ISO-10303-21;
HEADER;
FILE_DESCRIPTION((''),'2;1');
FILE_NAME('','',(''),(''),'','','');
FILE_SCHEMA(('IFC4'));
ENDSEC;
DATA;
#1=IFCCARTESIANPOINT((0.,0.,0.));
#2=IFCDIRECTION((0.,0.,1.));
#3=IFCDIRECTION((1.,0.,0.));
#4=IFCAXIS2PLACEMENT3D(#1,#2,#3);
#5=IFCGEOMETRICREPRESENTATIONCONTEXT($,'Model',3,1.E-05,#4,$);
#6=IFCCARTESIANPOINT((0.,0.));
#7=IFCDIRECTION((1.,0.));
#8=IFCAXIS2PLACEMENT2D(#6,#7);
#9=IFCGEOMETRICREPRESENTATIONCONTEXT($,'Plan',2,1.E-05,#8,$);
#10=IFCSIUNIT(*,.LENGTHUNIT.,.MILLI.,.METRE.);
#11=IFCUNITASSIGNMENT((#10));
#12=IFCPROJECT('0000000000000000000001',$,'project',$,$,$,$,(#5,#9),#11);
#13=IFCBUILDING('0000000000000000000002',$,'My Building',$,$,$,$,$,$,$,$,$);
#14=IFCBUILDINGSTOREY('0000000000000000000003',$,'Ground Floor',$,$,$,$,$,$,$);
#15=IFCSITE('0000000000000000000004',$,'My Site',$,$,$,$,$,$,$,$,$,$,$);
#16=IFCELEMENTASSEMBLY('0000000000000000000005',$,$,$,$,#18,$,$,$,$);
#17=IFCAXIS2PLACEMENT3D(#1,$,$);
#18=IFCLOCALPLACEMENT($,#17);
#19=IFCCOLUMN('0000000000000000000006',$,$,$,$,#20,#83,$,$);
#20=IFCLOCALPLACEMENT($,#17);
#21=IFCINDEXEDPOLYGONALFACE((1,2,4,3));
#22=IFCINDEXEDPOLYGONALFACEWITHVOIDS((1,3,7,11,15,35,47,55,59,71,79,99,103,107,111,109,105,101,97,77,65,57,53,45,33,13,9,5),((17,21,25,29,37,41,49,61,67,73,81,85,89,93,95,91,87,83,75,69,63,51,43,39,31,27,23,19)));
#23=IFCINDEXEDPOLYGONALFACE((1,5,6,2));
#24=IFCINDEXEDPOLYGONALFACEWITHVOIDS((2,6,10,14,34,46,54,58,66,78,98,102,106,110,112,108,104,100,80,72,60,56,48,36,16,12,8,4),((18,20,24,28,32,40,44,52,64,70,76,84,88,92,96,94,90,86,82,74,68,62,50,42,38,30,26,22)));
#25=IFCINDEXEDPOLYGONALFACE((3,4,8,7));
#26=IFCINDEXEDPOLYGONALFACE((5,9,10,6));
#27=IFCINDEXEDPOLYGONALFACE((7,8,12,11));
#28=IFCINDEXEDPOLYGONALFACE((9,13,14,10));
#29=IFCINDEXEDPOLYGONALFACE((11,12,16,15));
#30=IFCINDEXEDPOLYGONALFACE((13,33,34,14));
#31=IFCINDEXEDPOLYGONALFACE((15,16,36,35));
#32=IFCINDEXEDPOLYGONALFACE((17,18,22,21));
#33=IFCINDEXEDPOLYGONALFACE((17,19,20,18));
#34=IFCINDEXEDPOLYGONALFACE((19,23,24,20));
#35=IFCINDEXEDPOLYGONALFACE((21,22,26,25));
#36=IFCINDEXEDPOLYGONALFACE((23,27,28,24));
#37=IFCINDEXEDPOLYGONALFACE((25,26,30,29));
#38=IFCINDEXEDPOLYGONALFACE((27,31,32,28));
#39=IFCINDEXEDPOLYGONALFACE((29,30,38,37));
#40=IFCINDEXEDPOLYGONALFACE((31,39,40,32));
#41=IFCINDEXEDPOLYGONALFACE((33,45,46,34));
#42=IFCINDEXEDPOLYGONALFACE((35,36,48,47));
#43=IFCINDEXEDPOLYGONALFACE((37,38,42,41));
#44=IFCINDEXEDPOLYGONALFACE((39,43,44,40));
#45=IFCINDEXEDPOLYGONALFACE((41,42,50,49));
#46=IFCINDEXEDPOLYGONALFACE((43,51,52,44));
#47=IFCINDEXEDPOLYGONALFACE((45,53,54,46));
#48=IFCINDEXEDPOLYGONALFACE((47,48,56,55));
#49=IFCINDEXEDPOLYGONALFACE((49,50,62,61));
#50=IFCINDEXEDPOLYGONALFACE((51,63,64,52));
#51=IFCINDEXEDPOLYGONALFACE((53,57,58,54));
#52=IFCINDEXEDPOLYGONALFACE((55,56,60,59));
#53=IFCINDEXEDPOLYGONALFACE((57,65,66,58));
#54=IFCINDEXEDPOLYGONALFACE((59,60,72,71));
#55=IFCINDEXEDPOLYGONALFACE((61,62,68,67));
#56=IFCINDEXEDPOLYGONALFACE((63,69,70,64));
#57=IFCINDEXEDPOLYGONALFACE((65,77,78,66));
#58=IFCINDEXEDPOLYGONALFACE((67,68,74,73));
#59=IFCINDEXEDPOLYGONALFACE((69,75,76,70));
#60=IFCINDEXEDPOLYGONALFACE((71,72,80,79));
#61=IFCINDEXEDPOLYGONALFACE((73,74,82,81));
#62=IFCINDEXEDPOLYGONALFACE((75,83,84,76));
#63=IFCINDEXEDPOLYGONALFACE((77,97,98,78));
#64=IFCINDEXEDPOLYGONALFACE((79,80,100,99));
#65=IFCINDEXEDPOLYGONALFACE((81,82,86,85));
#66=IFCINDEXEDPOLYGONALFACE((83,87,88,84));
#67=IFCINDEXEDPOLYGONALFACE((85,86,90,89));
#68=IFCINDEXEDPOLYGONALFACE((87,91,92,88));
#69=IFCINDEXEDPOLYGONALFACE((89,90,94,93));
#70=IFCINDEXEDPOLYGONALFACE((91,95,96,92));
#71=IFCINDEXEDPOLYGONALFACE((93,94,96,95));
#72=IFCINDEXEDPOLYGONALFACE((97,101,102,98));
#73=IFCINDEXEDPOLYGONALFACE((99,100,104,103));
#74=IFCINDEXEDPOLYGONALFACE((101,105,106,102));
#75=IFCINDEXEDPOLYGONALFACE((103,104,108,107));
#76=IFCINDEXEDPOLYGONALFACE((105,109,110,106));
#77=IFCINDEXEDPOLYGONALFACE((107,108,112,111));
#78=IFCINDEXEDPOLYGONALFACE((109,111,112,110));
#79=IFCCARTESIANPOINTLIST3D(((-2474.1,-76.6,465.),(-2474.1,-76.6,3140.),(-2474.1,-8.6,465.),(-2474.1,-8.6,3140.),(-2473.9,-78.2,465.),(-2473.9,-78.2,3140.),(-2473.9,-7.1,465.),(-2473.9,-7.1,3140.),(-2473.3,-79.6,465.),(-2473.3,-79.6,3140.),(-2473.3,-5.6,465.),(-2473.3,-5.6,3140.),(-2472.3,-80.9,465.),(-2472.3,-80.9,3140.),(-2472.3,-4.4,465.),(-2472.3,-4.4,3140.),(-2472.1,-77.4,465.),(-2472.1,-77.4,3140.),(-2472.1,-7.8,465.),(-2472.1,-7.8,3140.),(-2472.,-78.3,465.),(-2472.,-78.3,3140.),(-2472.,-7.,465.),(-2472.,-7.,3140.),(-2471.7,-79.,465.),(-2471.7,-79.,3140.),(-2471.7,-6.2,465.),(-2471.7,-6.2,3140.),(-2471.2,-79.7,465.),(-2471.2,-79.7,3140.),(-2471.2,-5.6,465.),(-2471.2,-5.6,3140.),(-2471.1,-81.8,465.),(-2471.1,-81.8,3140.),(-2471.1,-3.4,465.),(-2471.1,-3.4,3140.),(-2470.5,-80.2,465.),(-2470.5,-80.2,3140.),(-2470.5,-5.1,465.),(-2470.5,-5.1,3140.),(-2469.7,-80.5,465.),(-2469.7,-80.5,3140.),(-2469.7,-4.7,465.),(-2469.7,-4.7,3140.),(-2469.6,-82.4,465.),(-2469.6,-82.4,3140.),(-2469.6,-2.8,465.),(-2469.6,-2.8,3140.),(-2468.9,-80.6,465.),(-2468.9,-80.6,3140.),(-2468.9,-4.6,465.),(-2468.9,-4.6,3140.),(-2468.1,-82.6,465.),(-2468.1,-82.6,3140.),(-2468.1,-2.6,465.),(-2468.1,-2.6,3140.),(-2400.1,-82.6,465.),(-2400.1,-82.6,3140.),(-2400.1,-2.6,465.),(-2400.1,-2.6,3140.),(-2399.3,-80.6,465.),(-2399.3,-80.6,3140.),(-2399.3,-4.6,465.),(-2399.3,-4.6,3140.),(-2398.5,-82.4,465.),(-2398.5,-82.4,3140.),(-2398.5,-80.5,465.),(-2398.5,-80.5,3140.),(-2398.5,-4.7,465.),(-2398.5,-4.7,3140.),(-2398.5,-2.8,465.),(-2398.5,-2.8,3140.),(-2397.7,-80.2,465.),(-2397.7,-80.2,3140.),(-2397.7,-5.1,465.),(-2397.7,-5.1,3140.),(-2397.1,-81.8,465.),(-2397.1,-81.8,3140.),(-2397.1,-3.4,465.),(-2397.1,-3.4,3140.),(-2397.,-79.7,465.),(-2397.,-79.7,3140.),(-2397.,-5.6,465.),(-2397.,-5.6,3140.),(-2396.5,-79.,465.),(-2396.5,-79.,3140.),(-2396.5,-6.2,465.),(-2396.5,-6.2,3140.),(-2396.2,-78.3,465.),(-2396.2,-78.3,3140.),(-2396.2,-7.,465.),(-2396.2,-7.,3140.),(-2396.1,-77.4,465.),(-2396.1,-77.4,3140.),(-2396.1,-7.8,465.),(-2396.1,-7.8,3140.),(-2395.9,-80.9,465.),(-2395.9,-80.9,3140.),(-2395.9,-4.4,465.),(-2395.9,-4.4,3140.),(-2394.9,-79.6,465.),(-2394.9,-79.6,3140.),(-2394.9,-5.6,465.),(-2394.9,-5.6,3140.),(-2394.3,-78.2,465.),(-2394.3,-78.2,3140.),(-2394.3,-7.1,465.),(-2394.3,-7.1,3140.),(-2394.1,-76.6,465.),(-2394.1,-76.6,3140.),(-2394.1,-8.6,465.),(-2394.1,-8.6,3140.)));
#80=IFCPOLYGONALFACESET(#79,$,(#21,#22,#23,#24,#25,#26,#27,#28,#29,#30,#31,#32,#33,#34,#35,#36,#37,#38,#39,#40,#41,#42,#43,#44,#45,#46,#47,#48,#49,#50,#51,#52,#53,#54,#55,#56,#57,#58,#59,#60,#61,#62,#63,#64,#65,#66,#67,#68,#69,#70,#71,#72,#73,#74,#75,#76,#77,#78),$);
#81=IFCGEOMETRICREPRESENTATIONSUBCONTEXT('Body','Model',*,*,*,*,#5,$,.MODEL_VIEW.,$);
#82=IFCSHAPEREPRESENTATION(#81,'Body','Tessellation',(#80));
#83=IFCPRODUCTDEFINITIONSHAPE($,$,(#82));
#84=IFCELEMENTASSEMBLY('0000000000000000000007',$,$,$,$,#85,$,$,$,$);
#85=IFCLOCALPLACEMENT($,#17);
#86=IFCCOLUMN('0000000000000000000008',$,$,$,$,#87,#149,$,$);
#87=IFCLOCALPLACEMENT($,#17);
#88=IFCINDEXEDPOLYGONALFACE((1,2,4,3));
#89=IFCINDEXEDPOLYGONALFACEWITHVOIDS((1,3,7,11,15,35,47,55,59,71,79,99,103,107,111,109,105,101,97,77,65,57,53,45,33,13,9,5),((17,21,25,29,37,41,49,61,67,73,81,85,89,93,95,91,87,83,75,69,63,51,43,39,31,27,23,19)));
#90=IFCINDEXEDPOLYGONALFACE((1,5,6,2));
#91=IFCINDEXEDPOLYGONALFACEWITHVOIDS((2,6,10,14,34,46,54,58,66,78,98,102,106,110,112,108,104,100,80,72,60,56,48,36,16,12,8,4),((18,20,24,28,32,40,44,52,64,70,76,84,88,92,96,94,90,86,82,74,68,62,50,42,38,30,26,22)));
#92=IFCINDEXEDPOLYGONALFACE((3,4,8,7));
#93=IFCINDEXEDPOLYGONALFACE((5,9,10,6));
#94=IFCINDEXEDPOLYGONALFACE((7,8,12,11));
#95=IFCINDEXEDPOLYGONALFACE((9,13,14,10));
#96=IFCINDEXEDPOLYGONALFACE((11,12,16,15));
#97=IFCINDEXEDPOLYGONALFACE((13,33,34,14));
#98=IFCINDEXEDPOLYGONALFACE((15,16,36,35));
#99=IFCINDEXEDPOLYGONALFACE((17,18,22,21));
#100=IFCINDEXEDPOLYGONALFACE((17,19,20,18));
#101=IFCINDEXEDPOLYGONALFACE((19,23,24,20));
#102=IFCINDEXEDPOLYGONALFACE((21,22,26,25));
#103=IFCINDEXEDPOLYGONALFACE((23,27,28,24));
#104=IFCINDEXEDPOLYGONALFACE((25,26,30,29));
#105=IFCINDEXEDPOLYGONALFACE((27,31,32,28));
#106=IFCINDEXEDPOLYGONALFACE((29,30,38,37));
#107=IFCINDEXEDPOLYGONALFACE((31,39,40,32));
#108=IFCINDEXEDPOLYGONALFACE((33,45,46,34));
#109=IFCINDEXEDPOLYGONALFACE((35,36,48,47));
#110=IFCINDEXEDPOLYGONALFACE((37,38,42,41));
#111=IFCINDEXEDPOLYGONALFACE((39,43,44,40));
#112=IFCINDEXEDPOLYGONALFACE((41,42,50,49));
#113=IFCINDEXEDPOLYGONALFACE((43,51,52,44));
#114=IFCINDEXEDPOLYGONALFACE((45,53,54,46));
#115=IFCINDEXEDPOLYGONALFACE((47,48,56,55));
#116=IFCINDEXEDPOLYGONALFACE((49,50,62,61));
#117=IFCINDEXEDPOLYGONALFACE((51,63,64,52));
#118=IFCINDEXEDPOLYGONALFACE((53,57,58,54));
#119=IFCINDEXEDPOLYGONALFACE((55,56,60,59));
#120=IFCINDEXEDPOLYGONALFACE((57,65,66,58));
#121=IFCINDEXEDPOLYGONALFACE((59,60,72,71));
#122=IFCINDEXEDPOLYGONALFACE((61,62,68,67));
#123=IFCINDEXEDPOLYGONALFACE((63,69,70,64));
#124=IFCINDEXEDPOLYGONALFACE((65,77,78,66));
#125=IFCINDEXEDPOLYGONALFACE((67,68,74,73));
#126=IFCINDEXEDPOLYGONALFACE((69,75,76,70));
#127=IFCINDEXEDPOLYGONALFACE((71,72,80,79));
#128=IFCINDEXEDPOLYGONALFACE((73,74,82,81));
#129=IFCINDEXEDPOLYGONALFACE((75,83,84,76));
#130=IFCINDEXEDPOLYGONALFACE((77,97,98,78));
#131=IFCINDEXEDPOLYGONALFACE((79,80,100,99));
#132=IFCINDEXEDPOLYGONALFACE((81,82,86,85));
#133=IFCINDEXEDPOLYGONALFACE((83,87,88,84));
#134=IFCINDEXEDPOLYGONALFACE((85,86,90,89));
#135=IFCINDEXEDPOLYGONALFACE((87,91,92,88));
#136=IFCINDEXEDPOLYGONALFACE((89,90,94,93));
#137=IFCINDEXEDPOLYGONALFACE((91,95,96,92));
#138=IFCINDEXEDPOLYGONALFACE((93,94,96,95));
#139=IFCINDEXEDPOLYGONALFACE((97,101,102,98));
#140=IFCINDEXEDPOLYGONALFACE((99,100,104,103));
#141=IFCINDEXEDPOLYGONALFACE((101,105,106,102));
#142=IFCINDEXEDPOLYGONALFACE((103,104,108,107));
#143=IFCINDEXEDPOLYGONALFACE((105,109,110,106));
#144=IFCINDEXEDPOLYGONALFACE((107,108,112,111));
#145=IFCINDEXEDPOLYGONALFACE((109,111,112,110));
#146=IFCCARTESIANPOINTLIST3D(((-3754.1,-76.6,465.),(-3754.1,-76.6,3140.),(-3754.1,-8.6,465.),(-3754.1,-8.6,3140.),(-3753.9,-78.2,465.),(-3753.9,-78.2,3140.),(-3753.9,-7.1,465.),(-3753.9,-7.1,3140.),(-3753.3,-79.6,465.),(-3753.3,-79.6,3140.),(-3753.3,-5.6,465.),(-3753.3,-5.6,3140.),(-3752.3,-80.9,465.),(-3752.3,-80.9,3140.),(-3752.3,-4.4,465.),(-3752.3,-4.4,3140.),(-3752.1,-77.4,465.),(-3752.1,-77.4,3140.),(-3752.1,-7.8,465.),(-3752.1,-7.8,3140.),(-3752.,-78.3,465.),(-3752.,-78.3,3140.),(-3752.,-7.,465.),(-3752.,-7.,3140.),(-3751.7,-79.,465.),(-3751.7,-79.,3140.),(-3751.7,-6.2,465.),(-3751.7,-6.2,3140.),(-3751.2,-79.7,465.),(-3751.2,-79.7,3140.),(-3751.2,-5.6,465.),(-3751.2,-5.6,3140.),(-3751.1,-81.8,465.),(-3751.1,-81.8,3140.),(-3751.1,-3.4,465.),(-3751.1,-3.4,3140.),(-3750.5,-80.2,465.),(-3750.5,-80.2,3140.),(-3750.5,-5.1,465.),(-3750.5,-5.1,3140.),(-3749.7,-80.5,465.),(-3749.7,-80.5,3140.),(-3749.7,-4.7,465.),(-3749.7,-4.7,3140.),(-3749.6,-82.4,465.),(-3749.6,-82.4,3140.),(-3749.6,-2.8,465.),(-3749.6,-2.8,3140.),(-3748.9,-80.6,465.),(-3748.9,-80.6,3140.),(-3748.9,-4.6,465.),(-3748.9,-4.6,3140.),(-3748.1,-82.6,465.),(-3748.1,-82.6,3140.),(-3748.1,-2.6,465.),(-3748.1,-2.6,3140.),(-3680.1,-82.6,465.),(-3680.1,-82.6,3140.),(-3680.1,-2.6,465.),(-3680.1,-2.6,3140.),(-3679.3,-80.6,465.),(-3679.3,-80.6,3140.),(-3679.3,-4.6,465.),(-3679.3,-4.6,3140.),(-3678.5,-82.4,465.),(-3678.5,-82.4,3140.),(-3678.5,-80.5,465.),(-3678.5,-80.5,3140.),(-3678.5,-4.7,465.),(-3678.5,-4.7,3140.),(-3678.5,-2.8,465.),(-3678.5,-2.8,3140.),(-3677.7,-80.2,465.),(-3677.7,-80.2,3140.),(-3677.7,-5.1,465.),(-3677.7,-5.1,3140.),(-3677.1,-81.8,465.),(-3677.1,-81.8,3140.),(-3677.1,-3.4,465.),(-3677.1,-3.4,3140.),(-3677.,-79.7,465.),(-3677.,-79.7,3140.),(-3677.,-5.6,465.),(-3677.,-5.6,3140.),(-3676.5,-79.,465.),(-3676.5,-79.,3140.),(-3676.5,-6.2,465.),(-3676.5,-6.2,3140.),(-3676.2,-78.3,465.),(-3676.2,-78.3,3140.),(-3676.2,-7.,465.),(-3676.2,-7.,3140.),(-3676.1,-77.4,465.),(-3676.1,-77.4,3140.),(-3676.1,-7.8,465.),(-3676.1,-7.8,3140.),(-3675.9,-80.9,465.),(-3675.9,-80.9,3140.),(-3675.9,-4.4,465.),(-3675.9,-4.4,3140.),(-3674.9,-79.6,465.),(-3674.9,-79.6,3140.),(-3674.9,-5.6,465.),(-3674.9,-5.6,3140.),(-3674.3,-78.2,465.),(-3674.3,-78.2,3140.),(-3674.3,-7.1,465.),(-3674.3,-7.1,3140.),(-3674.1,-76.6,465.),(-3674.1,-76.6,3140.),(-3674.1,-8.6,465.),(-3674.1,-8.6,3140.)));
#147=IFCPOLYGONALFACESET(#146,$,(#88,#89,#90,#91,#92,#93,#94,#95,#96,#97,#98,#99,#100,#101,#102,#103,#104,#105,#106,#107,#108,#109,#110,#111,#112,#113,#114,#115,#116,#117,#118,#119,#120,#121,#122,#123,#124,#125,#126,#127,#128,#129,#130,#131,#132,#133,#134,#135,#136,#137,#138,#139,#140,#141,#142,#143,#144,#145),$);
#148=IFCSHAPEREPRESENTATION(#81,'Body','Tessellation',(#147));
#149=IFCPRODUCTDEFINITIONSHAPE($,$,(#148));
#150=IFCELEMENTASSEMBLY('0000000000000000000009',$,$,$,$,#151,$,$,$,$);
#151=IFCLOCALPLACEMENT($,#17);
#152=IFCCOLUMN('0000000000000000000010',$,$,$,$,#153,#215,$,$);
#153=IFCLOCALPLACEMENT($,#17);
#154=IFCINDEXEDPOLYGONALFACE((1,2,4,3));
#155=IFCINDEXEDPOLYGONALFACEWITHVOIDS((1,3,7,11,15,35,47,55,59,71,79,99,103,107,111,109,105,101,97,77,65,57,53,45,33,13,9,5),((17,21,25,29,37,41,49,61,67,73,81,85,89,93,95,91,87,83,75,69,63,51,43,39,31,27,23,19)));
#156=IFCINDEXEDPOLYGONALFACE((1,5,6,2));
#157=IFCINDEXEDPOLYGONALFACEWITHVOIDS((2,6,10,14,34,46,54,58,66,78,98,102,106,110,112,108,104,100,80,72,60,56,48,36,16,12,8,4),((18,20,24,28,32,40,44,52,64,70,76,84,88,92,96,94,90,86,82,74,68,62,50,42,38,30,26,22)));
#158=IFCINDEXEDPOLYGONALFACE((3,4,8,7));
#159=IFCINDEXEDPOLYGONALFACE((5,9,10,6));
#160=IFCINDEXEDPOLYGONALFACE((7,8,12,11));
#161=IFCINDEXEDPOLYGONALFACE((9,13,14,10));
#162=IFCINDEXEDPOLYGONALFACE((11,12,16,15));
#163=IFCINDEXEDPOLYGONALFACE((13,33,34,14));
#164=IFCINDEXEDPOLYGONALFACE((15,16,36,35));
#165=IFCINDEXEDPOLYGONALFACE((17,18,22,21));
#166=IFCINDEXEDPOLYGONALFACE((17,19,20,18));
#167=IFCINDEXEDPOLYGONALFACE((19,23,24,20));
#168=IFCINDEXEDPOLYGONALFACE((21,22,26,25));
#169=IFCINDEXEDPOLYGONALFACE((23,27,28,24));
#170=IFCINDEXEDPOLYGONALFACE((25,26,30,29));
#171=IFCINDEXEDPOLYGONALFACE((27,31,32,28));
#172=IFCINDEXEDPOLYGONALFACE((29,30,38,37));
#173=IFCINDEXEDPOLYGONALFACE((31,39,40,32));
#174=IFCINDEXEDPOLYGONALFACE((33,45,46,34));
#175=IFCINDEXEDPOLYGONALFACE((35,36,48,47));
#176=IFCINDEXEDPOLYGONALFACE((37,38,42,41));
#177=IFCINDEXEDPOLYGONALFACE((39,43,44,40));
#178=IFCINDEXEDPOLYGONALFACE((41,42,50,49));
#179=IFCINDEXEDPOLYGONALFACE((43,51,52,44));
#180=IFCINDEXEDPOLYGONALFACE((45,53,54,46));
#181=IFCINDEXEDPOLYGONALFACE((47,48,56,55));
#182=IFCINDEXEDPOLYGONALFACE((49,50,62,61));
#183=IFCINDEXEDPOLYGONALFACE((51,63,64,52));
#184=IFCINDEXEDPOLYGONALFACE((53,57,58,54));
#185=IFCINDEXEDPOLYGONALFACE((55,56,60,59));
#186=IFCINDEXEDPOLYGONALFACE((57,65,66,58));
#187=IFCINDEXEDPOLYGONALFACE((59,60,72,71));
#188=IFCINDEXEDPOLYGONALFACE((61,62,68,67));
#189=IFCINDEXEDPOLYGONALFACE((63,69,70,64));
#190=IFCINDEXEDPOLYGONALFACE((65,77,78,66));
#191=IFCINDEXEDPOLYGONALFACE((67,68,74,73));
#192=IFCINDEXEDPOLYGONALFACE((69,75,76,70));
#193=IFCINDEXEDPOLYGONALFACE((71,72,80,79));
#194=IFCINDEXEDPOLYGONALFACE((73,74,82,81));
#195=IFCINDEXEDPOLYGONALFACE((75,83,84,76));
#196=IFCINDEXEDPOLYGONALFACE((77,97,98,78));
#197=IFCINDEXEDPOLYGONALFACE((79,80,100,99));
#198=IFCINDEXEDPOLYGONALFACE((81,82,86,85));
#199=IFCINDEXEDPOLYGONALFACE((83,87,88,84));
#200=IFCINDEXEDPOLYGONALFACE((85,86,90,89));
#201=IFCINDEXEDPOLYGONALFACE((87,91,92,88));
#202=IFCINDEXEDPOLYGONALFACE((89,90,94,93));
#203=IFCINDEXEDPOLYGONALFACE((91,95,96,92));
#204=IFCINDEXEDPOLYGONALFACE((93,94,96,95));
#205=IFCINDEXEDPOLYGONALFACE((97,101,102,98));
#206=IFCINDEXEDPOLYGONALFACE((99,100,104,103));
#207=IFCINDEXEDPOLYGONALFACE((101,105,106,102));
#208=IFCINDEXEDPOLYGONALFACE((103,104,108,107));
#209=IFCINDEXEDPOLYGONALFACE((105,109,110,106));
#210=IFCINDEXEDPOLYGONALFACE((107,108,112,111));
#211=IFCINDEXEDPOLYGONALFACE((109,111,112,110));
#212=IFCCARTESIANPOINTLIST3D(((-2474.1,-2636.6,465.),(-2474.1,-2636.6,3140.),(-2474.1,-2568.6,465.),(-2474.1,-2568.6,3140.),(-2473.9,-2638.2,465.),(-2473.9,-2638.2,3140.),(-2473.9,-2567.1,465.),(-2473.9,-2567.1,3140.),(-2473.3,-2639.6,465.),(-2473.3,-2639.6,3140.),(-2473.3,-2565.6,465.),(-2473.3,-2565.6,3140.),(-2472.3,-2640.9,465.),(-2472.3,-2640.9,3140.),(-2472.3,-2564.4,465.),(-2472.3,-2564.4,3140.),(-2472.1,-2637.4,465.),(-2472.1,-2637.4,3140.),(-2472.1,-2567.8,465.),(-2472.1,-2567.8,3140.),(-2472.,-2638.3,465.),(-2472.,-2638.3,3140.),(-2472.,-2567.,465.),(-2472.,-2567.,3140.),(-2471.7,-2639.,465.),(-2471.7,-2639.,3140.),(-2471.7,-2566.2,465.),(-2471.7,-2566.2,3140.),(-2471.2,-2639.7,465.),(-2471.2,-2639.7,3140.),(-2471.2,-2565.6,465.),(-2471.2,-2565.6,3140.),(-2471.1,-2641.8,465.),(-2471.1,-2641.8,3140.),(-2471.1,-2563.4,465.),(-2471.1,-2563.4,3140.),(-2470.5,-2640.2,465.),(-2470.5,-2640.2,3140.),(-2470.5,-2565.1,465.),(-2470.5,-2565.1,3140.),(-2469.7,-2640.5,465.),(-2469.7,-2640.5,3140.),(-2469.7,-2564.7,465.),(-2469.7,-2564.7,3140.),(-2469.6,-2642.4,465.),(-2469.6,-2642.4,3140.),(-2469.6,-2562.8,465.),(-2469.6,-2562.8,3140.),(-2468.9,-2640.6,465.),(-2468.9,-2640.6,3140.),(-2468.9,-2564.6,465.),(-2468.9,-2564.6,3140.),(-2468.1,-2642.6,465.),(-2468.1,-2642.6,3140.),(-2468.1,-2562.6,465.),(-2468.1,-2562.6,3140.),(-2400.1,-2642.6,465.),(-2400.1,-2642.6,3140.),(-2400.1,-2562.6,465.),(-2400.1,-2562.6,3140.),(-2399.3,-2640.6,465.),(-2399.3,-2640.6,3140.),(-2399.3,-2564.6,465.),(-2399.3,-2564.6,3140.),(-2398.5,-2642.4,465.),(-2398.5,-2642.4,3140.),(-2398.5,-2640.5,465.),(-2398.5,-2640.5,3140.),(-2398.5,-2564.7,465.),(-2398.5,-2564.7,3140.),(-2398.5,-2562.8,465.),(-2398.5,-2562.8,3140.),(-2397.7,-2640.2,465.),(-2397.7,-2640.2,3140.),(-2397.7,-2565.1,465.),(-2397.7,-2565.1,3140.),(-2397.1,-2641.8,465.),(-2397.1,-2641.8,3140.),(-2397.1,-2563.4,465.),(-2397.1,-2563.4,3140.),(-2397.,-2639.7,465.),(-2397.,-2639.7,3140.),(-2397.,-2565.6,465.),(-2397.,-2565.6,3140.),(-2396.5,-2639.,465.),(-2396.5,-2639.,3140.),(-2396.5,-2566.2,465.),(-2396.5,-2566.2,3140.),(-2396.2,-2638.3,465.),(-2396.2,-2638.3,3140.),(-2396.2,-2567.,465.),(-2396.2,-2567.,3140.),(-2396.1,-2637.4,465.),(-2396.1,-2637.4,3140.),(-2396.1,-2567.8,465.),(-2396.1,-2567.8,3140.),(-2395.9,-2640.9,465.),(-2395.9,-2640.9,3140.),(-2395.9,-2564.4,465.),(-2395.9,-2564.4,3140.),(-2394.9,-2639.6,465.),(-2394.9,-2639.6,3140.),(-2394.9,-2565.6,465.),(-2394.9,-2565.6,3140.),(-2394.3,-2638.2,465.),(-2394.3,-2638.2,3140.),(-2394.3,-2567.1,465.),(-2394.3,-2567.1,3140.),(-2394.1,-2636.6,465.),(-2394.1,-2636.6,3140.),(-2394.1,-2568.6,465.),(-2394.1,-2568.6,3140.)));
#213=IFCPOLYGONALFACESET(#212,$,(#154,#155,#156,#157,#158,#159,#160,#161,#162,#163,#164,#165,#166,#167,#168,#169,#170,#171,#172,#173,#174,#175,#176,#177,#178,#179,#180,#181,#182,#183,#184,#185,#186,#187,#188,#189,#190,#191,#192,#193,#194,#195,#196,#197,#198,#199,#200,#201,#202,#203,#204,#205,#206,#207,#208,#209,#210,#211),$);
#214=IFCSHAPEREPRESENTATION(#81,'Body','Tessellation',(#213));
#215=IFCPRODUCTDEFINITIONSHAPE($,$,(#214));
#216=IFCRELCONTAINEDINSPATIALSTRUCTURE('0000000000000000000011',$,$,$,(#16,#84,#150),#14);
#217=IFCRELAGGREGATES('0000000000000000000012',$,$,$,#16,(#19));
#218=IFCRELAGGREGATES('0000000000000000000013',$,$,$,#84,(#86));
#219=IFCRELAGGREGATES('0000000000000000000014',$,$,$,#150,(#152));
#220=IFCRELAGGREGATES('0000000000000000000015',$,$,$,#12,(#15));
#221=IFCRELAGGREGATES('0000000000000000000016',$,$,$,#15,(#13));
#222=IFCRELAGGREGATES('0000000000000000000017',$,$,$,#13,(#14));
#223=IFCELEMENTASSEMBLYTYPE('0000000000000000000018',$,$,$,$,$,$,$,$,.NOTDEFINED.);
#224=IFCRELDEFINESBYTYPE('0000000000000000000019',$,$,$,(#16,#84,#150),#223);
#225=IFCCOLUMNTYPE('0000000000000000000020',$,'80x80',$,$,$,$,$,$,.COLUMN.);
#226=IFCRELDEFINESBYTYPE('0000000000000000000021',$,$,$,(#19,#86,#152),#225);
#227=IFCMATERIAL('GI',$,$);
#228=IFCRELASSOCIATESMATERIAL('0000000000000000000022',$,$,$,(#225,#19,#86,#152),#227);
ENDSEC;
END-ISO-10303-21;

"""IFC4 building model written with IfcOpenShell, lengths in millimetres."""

from ifc_helpers import new_model, si_unit, frame, origin_with_axes, origin_2d_with_axis, place, context, subcontext, project, spatial, hollow_rectangle, extrude, material, material_profile, profile_set, profile_usage, type_object, element, aggregate, save


model = new_model("IFC4")

# Units and contexts
model_context = context("Model", 3, precision=1e-05, world=origin_with_axes())
plan_context = context("Plan", 2, precision=1e-05, world=origin_2d_with_axis())
body_context = subcontext(model_context, "Body", "Model", "MODEL_VIEW")
ifc_project = project(units=[si_unit("LENGTHUNIT", "METRE", prefix="MILLI")], contexts=[model_context, plan_context])

# Site, building, storey
site = spatial("IfcSite", under=ifc_project, Name="My Site")
building = spatial("IfcBuilding", under=site, Name="My Building")
storey = spatial("IfcBuildingStorey", under=building, Name="Ground Floor")

# Element assemblies, columns
element_assembly_type_1 = type_object("IfcElementAssemblyType", PredefinedType="NOTDEFINED")
ifc_material_1 = material(Name="GI")
ifc_material_profile_1 = material_profile(ifc_material_1, hollow_rectangle(XDim=80.0, YDim=80.0, WallThickness=2.0, InnerFilletRadius=3.2, OuterFilletRadius=6.0))
ifc_profile_set_1 = profile_set([ifc_material_profile_1], Name="80x80 GI Rectangular Hollow")
column_type = type_object("IfcColumnType", Name="80x80", PredefinedType="COLUMN", material=ifc_profile_set_1)
assembly_1_placement = place(None, frame((-2434.1, -42.6, 465.0), z_axis=(0.0, 0.0, 1.0), x_axis=(1.0, 0.0, 0.0)))
assembly_1 = element("IfcElementAssembly", 1, at=assembly_1_placement, inside=storey, type_object=element_assembly_type_1)
ifc_profile_usage_1 = profile_usage(ifc_profile_set_1)
column_1_placement = place(assembly_1_placement, origin_with_axes())
column_1 = element("IfcColumn", 2, at=column_1_placement, type_object=column_type, material=ifc_profile_usage_1, context=body_context, shape_type="SweptSolid", body=[
    extrude(hollow_rectangle(XDim=80.0, YDim=80.0, WallThickness=2.0, InnerFilletRadius=3.2, OuterFilletRadius=6.0), origin_with_axes(), (0.0, 0.0, 1.0), 2675.0),
])
aggregate(assembly_1, [column_1])
assembly_2_placement = place(None, frame((-3714.1, -42.6, 465.0), z_axis=(0.0, 0.0, 1.0), x_axis=(1.0, 0.0, 0.0)))
assembly_2 = element("IfcElementAssembly", 3, at=assembly_2_placement, inside=storey, type_object=element_assembly_type_1)
ifc_profile_usage_2 = profile_usage(ifc_profile_set_1)
column_2_placement = place(assembly_2_placement, origin_with_axes())
column_2 = element("IfcColumn", 4, at=column_2_placement, type_object=column_type, material=ifc_profile_usage_2, context=body_context, shape_type="SweptSolid", body=[
    extrude(hollow_rectangle(XDim=80.0, YDim=80.0, WallThickness=2.0, InnerFilletRadius=3.2, OuterFilletRadius=6.0), origin_with_axes(), (0.0, 0.0, 1.0), 2675.0),
])
aggregate(assembly_2, [column_2])
assembly_3_placement = place(None, frame((-2434.1, -2602.6, 465.0), z_axis=(0.0, 0.0, 1.0), x_axis=(1.0, 0.0, 0.0)))
assembly_3 = element("IfcElementAssembly", 5, at=assembly_3_placement, inside=storey, type_object=element_assembly_type_1)
ifc_profile_usage_3 = profile_usage(ifc_profile_set_1)
column_3_placement = place(assembly_3_placement, origin_with_axes())
column_3 = element("IfcColumn", 6, at=column_3_placement, type_object=column_type, material=ifc_profile_usage_3, context=body_context, shape_type="SweptSolid", body=[
    extrude(hollow_rectangle(XDim=80.0, YDim=80.0, WallThickness=2.0, InnerFilletRadius=3.2, OuterFilletRadius=6.0), origin_with_axes(), (0.0, 0.0, 1.0), 2675.0),
])
aggregate(assembly_3, [column_3])

save(model, "model.ifc")
